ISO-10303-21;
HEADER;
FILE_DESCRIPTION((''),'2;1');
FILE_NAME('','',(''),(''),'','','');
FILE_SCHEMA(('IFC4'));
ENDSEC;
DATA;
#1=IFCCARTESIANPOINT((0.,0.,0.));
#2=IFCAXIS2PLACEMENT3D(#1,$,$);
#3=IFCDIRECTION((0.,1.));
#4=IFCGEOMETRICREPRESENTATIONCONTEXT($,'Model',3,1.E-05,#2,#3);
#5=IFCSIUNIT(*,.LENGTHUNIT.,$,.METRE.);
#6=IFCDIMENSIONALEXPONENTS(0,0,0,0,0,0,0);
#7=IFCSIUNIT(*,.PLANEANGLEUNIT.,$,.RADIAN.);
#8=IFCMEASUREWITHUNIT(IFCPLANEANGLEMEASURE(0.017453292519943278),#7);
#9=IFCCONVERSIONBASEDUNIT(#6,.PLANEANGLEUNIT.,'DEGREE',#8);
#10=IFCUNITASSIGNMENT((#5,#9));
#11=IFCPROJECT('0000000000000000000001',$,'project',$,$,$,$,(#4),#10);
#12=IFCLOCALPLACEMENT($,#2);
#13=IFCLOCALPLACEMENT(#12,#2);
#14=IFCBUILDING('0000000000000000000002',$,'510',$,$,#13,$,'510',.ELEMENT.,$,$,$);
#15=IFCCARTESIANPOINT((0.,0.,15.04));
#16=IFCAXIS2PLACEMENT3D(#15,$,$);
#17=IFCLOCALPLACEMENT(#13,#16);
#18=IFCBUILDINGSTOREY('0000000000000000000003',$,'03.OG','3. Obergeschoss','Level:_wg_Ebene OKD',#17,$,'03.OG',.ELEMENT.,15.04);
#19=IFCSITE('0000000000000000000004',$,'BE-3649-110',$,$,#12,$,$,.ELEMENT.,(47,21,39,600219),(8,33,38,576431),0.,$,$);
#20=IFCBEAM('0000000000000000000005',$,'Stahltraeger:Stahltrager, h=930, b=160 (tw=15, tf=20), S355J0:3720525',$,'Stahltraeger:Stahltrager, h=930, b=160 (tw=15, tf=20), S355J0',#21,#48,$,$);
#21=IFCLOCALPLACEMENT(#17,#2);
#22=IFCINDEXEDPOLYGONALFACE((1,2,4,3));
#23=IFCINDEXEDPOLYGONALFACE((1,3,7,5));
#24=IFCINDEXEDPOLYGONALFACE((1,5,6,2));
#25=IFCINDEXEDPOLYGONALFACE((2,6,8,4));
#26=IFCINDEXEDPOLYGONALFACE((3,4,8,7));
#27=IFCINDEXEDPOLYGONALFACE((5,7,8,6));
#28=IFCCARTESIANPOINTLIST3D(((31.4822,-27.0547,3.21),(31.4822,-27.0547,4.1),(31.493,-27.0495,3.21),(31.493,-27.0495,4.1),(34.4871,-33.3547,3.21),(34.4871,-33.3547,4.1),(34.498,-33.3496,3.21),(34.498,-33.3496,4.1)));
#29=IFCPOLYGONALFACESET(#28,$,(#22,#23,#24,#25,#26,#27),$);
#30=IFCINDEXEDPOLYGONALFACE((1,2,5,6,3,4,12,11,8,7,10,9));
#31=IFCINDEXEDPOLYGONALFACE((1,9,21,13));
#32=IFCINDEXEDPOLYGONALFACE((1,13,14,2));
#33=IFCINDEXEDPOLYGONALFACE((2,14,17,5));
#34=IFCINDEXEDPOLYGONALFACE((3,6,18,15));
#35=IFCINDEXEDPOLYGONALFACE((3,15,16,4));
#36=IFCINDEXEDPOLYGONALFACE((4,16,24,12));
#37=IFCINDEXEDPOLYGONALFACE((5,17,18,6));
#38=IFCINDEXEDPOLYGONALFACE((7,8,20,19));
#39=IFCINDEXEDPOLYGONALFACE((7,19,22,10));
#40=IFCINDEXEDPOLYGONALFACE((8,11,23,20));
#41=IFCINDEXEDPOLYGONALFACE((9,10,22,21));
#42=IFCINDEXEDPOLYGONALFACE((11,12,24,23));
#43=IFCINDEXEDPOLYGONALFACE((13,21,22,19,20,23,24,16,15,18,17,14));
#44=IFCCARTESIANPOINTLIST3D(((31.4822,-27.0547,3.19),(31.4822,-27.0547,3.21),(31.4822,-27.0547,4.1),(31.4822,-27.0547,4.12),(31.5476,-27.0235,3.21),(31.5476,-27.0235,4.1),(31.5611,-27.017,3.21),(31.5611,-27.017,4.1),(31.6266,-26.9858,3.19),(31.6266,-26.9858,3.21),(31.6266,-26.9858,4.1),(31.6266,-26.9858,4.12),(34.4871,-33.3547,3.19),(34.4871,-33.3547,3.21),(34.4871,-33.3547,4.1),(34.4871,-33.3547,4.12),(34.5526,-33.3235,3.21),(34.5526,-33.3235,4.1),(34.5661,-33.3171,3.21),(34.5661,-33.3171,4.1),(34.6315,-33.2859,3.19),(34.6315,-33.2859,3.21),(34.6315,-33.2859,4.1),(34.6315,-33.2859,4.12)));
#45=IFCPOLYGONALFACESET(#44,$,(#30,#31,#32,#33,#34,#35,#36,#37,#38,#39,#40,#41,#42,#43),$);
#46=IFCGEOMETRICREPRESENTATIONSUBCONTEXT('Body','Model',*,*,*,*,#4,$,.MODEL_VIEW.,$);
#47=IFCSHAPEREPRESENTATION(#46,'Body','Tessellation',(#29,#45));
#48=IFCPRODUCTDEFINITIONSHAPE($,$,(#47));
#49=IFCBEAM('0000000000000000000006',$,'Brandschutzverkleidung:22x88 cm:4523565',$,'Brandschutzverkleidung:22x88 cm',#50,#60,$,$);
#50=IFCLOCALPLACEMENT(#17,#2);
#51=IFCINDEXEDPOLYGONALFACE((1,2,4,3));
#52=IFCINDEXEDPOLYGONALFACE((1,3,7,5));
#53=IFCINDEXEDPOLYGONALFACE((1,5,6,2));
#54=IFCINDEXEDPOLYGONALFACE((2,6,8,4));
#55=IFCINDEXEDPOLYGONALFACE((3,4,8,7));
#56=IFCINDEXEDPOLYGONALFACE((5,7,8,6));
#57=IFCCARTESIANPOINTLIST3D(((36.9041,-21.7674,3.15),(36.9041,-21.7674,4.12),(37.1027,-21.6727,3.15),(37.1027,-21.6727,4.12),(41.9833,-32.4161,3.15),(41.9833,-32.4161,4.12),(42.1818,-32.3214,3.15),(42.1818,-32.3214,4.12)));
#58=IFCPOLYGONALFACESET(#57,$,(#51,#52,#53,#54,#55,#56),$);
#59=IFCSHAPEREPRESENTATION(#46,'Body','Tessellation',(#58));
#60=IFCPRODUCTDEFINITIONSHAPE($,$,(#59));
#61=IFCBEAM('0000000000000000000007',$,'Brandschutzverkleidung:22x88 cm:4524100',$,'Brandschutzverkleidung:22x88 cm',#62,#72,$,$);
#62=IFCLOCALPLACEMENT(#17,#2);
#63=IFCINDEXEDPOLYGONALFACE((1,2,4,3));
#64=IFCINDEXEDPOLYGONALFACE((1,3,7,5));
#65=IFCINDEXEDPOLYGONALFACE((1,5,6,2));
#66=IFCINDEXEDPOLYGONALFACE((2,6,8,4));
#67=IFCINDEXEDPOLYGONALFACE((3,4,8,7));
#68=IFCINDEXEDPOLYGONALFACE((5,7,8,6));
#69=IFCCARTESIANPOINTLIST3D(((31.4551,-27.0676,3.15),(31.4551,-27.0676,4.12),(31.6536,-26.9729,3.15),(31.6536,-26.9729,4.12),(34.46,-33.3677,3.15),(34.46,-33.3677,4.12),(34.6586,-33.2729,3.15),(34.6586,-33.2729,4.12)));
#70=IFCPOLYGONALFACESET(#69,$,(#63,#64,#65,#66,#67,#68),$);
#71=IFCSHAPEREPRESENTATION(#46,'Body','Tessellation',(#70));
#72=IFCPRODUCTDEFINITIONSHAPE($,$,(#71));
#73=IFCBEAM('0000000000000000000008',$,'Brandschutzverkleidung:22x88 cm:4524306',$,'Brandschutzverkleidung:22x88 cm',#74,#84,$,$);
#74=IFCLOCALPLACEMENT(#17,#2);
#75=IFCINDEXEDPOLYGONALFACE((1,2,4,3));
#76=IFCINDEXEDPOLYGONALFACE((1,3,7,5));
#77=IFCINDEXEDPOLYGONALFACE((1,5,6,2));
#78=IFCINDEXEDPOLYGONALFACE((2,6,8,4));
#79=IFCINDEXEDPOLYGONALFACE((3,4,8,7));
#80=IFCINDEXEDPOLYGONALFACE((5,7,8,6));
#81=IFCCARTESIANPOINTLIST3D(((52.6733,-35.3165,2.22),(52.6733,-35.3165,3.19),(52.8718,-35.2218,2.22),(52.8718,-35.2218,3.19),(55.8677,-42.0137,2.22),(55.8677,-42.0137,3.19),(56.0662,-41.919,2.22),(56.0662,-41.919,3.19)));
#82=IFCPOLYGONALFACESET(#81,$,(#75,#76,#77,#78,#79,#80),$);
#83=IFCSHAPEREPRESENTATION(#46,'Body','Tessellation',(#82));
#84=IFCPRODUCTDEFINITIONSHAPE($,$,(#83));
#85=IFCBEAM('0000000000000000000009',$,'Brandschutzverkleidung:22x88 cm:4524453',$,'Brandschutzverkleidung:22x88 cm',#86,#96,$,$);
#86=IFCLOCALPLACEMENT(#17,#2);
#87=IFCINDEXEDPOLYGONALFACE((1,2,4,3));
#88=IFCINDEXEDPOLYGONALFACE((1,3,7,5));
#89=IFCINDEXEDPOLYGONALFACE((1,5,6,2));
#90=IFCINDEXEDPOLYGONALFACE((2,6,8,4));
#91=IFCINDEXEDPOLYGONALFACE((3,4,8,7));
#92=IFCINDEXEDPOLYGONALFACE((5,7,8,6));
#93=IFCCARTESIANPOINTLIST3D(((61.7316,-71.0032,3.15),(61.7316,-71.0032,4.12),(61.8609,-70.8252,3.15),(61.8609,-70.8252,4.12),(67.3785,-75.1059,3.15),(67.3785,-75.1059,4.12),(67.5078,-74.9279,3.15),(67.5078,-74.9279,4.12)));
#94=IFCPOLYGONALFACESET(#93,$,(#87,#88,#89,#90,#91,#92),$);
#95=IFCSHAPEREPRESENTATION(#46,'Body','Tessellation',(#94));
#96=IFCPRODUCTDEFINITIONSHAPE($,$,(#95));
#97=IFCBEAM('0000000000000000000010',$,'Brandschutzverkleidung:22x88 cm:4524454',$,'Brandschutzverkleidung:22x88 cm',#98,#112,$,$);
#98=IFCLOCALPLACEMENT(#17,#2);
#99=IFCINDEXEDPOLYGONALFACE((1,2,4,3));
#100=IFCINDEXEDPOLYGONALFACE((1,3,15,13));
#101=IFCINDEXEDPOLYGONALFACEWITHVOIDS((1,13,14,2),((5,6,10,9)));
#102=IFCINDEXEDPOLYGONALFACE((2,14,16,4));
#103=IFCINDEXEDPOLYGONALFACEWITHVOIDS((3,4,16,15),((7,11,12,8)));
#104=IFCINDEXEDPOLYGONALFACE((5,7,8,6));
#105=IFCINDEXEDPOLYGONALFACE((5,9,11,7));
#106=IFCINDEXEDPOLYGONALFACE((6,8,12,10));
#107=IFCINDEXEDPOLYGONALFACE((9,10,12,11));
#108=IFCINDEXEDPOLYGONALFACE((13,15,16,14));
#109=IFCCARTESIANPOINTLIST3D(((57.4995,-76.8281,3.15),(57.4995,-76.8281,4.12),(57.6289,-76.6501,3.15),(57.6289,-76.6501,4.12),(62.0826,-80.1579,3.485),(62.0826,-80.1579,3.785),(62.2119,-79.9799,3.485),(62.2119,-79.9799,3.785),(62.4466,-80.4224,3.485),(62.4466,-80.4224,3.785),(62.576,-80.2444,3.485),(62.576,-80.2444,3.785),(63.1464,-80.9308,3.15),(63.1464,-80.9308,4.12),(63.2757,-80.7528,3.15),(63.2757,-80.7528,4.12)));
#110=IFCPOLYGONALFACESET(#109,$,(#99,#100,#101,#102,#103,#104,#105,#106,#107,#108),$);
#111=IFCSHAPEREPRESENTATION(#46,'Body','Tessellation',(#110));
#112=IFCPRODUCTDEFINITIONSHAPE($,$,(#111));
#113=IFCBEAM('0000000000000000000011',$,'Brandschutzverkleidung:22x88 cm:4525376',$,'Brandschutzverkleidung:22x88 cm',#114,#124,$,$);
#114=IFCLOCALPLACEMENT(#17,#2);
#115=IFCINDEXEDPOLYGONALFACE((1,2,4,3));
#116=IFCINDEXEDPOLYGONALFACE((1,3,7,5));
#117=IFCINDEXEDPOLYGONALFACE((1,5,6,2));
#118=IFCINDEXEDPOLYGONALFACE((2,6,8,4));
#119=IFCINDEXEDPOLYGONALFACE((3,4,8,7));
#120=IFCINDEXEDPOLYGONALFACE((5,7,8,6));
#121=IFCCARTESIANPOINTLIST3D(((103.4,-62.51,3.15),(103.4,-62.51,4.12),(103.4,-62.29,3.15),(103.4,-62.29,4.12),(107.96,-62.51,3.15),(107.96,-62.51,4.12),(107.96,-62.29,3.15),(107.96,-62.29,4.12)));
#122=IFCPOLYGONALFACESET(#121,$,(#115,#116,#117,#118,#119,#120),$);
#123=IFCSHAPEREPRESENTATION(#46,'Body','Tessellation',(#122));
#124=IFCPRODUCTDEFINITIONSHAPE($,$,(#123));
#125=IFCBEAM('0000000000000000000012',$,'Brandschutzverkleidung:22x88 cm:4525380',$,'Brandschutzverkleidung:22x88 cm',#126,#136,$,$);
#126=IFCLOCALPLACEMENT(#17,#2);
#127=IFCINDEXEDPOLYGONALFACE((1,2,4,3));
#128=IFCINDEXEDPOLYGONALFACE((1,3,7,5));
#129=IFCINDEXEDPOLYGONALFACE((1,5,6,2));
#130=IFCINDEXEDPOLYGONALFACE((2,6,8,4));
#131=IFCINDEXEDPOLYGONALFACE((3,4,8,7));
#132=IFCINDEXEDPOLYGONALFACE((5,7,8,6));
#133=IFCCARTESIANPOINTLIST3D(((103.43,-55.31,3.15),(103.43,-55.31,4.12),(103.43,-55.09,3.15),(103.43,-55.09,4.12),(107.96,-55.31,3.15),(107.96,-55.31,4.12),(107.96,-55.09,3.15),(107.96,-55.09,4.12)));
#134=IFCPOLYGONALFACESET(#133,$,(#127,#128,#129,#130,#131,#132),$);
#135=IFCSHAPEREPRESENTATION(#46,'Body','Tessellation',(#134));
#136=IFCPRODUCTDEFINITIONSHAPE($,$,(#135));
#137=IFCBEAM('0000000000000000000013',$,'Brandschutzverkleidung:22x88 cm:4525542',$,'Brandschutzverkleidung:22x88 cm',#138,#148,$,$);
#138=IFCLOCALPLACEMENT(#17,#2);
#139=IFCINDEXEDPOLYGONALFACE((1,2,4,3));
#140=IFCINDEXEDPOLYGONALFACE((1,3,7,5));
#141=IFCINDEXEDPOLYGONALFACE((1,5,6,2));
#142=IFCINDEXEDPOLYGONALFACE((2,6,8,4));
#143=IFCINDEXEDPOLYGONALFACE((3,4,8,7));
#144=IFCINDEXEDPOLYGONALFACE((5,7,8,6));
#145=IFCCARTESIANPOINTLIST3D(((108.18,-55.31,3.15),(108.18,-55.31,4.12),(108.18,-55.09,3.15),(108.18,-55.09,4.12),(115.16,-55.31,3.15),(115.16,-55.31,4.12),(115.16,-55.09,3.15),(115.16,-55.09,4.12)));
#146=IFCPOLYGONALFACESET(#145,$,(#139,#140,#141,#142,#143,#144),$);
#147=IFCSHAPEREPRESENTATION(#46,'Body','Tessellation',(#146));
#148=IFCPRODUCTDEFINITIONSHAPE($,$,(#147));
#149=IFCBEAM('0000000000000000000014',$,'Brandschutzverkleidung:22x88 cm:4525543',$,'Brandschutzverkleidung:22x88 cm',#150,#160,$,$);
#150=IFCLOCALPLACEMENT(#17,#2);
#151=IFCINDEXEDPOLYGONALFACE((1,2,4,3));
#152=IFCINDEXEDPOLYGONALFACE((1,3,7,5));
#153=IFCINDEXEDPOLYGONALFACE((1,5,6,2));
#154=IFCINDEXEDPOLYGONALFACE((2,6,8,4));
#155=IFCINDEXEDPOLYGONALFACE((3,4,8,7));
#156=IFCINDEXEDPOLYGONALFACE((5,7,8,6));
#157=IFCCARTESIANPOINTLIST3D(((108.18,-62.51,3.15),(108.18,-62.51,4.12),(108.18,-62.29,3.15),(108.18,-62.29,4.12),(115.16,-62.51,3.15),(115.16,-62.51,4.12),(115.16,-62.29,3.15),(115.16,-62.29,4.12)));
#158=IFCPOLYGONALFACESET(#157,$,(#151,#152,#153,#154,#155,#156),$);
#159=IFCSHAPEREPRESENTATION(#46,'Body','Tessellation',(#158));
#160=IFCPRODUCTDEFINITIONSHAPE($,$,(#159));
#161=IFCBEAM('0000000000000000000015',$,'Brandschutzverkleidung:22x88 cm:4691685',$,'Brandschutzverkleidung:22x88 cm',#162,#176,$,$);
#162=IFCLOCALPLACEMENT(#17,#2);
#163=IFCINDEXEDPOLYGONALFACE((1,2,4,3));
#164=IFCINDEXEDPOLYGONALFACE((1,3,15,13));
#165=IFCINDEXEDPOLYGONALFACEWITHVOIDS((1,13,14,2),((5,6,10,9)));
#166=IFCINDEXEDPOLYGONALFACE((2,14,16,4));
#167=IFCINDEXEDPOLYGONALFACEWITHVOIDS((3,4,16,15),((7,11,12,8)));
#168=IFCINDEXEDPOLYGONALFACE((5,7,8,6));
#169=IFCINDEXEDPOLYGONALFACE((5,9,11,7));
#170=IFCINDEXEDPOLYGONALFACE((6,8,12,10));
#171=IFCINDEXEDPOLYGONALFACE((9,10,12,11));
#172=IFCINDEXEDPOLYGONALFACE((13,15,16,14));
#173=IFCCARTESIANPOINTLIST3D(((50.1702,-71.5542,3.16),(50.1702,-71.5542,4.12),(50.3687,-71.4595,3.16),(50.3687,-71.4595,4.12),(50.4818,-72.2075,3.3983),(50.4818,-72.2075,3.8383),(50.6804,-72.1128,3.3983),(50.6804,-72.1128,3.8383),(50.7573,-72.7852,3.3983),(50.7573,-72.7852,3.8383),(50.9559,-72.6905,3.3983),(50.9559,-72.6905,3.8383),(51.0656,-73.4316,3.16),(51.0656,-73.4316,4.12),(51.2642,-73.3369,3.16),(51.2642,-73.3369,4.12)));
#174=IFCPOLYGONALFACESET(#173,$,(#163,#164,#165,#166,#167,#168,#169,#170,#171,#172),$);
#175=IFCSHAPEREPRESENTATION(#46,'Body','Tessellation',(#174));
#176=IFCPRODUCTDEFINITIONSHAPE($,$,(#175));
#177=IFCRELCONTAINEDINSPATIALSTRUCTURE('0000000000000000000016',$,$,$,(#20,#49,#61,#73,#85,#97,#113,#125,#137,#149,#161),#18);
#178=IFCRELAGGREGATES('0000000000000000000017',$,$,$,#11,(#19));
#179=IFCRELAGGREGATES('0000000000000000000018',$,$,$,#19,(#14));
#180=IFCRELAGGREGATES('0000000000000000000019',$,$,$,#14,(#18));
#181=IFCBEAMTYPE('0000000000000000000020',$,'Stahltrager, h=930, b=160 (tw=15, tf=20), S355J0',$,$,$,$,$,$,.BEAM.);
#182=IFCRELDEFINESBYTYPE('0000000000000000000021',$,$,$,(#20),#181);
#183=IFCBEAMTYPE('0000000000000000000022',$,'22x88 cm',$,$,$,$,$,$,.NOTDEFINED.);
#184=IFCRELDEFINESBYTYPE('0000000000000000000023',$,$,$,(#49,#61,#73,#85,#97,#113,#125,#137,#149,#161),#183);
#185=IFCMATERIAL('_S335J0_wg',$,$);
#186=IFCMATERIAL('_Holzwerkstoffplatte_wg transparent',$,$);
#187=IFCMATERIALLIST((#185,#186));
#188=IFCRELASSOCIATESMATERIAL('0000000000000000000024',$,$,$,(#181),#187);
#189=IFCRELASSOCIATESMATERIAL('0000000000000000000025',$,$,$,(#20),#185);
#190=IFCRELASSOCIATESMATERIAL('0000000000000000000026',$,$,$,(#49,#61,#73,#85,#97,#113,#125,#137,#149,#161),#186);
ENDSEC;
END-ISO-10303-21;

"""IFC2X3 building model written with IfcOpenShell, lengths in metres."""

from ifc_helpers import new_model, entity, si_unit, converted_unit, direction, frame, frame_2d, origin, origin_2d_with_axis, place, context, subcontext, project, spatial, polyline, rectangle, i_section, outline, extrude, source, transform, mapped, material, material_list, type_object, type_shapes, element, save


model = new_model("IFC2X3")

# Units and contexts
model_context = context("Model", 3, precision=1e-05, world=origin(), true_north=direction((0.0, 1.0)))
body_context = subcontext(model_context, "Body", "Model", "MODEL_VIEW")
ifc_project = project(units=[si_unit("LENGTHUNIT", "METRE"), converted_unit("PLANEANGLEUNIT", "DEGREE", entity("IfcPlaneAngleMeasure", 0.017453292519943278), si_unit("PLANEANGLEUNIT", "RADIAN"), dimensions=[0, 0, 0, 0, 0, 0, 0])], contexts=[model_context])

# Site, building, storey
site_placement = place(None, origin())
site = spatial("IfcSite", under=ifc_project, at=site_placement, Name="BE-3649-110", CompositionType="ELEMENT", RefLatitude=(47, 21, 39, 600219), RefLongitude=(8, 33, 38, 576431), RefElevation=0.0)
building_placement = place(site_placement, origin())
building = spatial("IfcBuilding", under=site, at=building_placement, Name="510", LongName="510", CompositionType="ELEMENT")
storey_placement = place(building_placement, frame((0.0, 0.0, 15.04)))
storey = spatial("IfcBuildingStorey", under=building, at=storey_placement, Name="03.OG", Description="3. Obergeschoss", ObjectType="Level:_wg_Ebene OKD", LongName="03.OG", CompositionType="ELEMENT", Elevation=15.04)

# Beams
ifc_material_1 = material(Name="_S335J0_wg")
ifc_material_2 = material(Name="_Holzwerkstoffplatte_wg transparent")
ifc_material_list = material_list([ifc_material_1, ifc_material_2])
beam_type_1 = type_object("IfcBeamType", Name="Stahltrager, h=930, b=160 (tw=15, tf=20), S355J0", PredefinedType="BEAM", material=ifc_material_list)
shared_shape_1 = source(origin(), body_context, "Body", "SweptSolid", [
    extrude(rectangle(XDim=0.89, YDim=0.012, at=frame_2d((0.0, 0.0), x_axis=(1.0, 0.0))), frame((31.4876, -27.0521, 18.695), z_axis=(0.430511, -0.902585, 0.0), x_axis=(0.0, 0.0, -1.0)), (0.0, 0.0, 1.0), 6.98),
    extrude(i_section(OverallWidth=0.16, OverallDepth=0.93, WebThickness=0.015, FlangeThickness=0.02, at=frame_2d((0.0, 0.0), x_axis=(0.0, 1.0))), frame((31.5544, -27.0203, 18.695), z_axis=(0.430511, -0.902585, 0.0), x_axis=(0.0, 0.0, -1.0)), (0.0, 0.0, 1.0), 6.98),
])
type_shapes(beam_type_1, [shared_shape_1])
beam_1_placement = place(storey_placement, frame((0.0, 0.0, -15.04)))
element("IfcBeam", 1, at=beam_1_placement, inside=storey, type_object=beam_type_1, material=ifc_material_1, Name="Stahltraeger:Stahltrager, h=930, b=160 (tw=15, tf=20), S355J0:3720525", ObjectType="Stahltraeger:Stahltrager, h=930, b=160 (tw=15, tf=20), S355J0", context=body_context, shape_type="MappedRepresentation", body=[
    mapped(shared_shape_1, transform((0.0, 0.0, 0.0), scale=1.0)),
])
beam_type_2 = type_object("IfcBeamType", Name="22x88 cm", PredefinedType="NOTDEFINED")
beam_2_placement = place(storey_placement, frame((0.0, 0.0, 3.635)))
element("IfcBeam", 2, at=beam_2_placement, inside=storey, type_object=beam_type_2, material=ifc_material_2, Name="Brandschutzverkleidung:22x88 cm:4523565", ObjectType="Brandschutzverkleidung:22x88 cm", context=body_context, shape_type="SweptSolid", body=[
    extrude(rectangle(XDim=0.97, YDim=0.22, at=frame_2d((0.0, 0.0), x_axis=(0.0, 1.0))), frame((42.0825, -32.3687, 0.0), z_axis=(-0.430511, 0.902585, 0.0), x_axis=(0.902585, 0.430511, 0.0)), (0.0, 0.0, 1.0), 11.798),
])
beam_3_placement = place(storey_placement, frame((0.0, 0.0, 3.635)))
element("IfcBeam", 3, at=beam_3_placement, inside=storey, type_object=beam_type_2, material=ifc_material_2, Name="Brandschutzverkleidung:22x88 cm:4524100", ObjectType="Brandschutzverkleidung:22x88 cm", context=body_context, shape_type="SweptSolid", body=[
    extrude(rectangle(XDim=0.97, YDim=0.22, at=frame_2d((0.0, 0.0), x_axis=(0.0, 1.0))), frame((34.5593, -33.3203, 0.0), z_axis=(-0.430511, 0.902585, 0.0), x_axis=(0.902585, 0.430511, 0.0)), (0.0, 0.0, 1.0), 6.98),
])
beam_4_placement = place(storey_placement, frame((0.0, 0.0, 2.705)))
element("IfcBeam", 4, at=beam_4_placement, inside=storey, type_object=beam_type_2, material=ifc_material_2, Name="Brandschutzverkleidung:22x88 cm:4524306", ObjectType="Brandschutzverkleidung:22x88 cm", context=body_context, shape_type="SweptSolid", body=[
    extrude(rectangle(XDim=0.97, YDim=0.22, at=frame_2d((0.0, 0.1517), x_axis=(0.0, 1.0))), frame((55.967, -41.9663, 0.1517), z_axis=(-0.430511, 0.902585, 0.0), x_axis=(0.902585, 0.430511, 0.0)), (0.0, 0.0, 1.0), 7.42),
])
beam_5_placement = place(storey_placement, frame((0.0, 0.0, 3.635)))
element("IfcBeam", 5, at=beam_5_placement, inside=storey, type_object=beam_type_2, material=ifc_material_2, Name="Brandschutzverkleidung:22x88 cm:4524453", ObjectType="Brandschutzverkleidung:22x88 cm", context=body_context, shape_type="SweptSolid", body=[
    extrude(rectangle(XDim=0.97, YDim=0.22, at=origin_2d_with_axis()), frame((61.7962, -70.9142, 0.0), z_axis=(0.809017, -0.587785, 0.0), x_axis=(0.0, 0.0, -1.0)), (0.0, 0.0, 1.0), 6.98),
])
beam_6_placement = place(storey_placement, frame((0.0, 0.0, 3.635)))
element("IfcBeam", 6, at=beam_6_placement, inside=storey, type_object=beam_type_2, material=ifc_material_2, Name="Brandschutzverkleidung:22x88 cm:4524454", ObjectType="Brandschutzverkleidung:22x88 cm", context=body_context, shape_type="SweptSolid", body=[
    extrude(outline(polyline([(-3.4899, -0.485), (3.49, -0.485), (3.49, 0.485), (-3.4899, 0.485), (-3.4899, -0.485)]), holes=[polyline([(2.175, -0.15), (2.175, 0.15), (2.625, 0.15), (2.625, -0.15), (2.175, -0.15)])]), frame((60.323, -78.8795, 0.0), z_axis=(0.587785, 0.809017, 0.0), x_axis=(0.809017, -0.587785, 0.0)), (0.0, 0.0, 1.0), 0.22),
])
beam_7_placement = place(storey_placement, frame((0.0, 0.0, 3.635)))
element("IfcBeam", 7, at=beam_7_placement, inside=storey, type_object=beam_type_2, material=ifc_material_2, Name="Brandschutzverkleidung:22x88 cm:4525376", ObjectType="Brandschutzverkleidung:22x88 cm", context=body_context, shape_type="SweptSolid", body=[
    extrude(rectangle(XDim=0.97, YDim=0.22, at=origin_2d_with_axis()), frame((103.4, -62.4, 0.0), z_axis=(1.0, 0.0, 0.0), x_axis=(0.0, 0.0, -1.0)), (0.0, 0.0, 1.0), 4.56),
])
beam_8_placement = place(storey_placement, frame((0.0, 0.0, 3.635)))
element("IfcBeam", 8, at=beam_8_placement, inside=storey, type_object=beam_type_2, material=ifc_material_2, Name="Brandschutzverkleidung:22x88 cm:4525380", ObjectType="Brandschutzverkleidung:22x88 cm", context=body_context, shape_type="SweptSolid", body=[
    extrude(rectangle(XDim=0.97, YDim=0.22, at=origin_2d_with_axis()), frame((103.43, -55.2, 0.0), z_axis=(1.0, 0.0, 0.0), x_axis=(0.0, 0.0, -1.0)), (0.0, 0.0, 1.0), 4.53),
])
beam_9_placement = place(storey_placement, frame((0.0, 0.0, 3.635)))
element("IfcBeam", 9, at=beam_9_placement, inside=storey, type_object=beam_type_2, material=ifc_material_2, Name="Brandschutzverkleidung:22x88 cm:4525542", ObjectType="Brandschutzverkleidung:22x88 cm", context=body_context, shape_type="SweptSolid", body=[
    extrude(rectangle(XDim=0.97, YDim=0.22, at=origin_2d_with_axis()), frame((108.18, -55.2, 0.0), z_axis=(1.0, 0.0, 0.0), x_axis=(0.0, 0.0, -1.0)), (0.0, 0.0, 1.0), 6.98),
])
beam_10_placement = place(storey_placement, frame((0.0, 0.0, 3.635)))
element("IfcBeam", 10, at=beam_10_placement, inside=storey, type_object=beam_type_2, material=ifc_material_2, Name="Brandschutzverkleidung:22x88 cm:4525543", ObjectType="Brandschutzverkleidung:22x88 cm", context=body_context, shape_type="SweptSolid", body=[
    extrude(rectangle(XDim=0.97, YDim=0.22, at=origin_2d_with_axis()), frame((108.18, -62.4, 0.0), z_axis=(1.0, 0.0, 0.0), x_axis=(0.0, 0.0, -1.0)), (0.0, 0.0, 1.0), 6.98),
])
beam_11_placement = place(storey_placement, frame((0.0, 0.0, 3.64)))
element("IfcBeam", 11, at=beam_11_placement, inside=storey, type_object=beam_type_2, material=ifc_material_2, Name="Brandschutzverkleidung:22x88 cm:4691685", ObjectType="Brandschutzverkleidung:22x88 cm", context=body_context, shape_type="SweptSolid", body=[
    extrude(outline(polyline([(-1.04, -0.48), (1.04, -0.48), (1.04, 0.48), (-1.04, 0.48), (-1.04, -0.48)]), holes=[polyline([(0.3238, 0.2417), (0.3238, -0.1983), (-0.3162, -0.1983), (-0.3162, 0.2417), (0.3238, 0.2417)])]), frame((50.6179, -72.4929, 0.0), z_axis=(0.902585, 0.430511, 0.0), x_axis=(0.430511, -0.902585, 0.0)), (0.0, 0.0, 1.0), 0.22),
])

save(model, "model.ifc")
